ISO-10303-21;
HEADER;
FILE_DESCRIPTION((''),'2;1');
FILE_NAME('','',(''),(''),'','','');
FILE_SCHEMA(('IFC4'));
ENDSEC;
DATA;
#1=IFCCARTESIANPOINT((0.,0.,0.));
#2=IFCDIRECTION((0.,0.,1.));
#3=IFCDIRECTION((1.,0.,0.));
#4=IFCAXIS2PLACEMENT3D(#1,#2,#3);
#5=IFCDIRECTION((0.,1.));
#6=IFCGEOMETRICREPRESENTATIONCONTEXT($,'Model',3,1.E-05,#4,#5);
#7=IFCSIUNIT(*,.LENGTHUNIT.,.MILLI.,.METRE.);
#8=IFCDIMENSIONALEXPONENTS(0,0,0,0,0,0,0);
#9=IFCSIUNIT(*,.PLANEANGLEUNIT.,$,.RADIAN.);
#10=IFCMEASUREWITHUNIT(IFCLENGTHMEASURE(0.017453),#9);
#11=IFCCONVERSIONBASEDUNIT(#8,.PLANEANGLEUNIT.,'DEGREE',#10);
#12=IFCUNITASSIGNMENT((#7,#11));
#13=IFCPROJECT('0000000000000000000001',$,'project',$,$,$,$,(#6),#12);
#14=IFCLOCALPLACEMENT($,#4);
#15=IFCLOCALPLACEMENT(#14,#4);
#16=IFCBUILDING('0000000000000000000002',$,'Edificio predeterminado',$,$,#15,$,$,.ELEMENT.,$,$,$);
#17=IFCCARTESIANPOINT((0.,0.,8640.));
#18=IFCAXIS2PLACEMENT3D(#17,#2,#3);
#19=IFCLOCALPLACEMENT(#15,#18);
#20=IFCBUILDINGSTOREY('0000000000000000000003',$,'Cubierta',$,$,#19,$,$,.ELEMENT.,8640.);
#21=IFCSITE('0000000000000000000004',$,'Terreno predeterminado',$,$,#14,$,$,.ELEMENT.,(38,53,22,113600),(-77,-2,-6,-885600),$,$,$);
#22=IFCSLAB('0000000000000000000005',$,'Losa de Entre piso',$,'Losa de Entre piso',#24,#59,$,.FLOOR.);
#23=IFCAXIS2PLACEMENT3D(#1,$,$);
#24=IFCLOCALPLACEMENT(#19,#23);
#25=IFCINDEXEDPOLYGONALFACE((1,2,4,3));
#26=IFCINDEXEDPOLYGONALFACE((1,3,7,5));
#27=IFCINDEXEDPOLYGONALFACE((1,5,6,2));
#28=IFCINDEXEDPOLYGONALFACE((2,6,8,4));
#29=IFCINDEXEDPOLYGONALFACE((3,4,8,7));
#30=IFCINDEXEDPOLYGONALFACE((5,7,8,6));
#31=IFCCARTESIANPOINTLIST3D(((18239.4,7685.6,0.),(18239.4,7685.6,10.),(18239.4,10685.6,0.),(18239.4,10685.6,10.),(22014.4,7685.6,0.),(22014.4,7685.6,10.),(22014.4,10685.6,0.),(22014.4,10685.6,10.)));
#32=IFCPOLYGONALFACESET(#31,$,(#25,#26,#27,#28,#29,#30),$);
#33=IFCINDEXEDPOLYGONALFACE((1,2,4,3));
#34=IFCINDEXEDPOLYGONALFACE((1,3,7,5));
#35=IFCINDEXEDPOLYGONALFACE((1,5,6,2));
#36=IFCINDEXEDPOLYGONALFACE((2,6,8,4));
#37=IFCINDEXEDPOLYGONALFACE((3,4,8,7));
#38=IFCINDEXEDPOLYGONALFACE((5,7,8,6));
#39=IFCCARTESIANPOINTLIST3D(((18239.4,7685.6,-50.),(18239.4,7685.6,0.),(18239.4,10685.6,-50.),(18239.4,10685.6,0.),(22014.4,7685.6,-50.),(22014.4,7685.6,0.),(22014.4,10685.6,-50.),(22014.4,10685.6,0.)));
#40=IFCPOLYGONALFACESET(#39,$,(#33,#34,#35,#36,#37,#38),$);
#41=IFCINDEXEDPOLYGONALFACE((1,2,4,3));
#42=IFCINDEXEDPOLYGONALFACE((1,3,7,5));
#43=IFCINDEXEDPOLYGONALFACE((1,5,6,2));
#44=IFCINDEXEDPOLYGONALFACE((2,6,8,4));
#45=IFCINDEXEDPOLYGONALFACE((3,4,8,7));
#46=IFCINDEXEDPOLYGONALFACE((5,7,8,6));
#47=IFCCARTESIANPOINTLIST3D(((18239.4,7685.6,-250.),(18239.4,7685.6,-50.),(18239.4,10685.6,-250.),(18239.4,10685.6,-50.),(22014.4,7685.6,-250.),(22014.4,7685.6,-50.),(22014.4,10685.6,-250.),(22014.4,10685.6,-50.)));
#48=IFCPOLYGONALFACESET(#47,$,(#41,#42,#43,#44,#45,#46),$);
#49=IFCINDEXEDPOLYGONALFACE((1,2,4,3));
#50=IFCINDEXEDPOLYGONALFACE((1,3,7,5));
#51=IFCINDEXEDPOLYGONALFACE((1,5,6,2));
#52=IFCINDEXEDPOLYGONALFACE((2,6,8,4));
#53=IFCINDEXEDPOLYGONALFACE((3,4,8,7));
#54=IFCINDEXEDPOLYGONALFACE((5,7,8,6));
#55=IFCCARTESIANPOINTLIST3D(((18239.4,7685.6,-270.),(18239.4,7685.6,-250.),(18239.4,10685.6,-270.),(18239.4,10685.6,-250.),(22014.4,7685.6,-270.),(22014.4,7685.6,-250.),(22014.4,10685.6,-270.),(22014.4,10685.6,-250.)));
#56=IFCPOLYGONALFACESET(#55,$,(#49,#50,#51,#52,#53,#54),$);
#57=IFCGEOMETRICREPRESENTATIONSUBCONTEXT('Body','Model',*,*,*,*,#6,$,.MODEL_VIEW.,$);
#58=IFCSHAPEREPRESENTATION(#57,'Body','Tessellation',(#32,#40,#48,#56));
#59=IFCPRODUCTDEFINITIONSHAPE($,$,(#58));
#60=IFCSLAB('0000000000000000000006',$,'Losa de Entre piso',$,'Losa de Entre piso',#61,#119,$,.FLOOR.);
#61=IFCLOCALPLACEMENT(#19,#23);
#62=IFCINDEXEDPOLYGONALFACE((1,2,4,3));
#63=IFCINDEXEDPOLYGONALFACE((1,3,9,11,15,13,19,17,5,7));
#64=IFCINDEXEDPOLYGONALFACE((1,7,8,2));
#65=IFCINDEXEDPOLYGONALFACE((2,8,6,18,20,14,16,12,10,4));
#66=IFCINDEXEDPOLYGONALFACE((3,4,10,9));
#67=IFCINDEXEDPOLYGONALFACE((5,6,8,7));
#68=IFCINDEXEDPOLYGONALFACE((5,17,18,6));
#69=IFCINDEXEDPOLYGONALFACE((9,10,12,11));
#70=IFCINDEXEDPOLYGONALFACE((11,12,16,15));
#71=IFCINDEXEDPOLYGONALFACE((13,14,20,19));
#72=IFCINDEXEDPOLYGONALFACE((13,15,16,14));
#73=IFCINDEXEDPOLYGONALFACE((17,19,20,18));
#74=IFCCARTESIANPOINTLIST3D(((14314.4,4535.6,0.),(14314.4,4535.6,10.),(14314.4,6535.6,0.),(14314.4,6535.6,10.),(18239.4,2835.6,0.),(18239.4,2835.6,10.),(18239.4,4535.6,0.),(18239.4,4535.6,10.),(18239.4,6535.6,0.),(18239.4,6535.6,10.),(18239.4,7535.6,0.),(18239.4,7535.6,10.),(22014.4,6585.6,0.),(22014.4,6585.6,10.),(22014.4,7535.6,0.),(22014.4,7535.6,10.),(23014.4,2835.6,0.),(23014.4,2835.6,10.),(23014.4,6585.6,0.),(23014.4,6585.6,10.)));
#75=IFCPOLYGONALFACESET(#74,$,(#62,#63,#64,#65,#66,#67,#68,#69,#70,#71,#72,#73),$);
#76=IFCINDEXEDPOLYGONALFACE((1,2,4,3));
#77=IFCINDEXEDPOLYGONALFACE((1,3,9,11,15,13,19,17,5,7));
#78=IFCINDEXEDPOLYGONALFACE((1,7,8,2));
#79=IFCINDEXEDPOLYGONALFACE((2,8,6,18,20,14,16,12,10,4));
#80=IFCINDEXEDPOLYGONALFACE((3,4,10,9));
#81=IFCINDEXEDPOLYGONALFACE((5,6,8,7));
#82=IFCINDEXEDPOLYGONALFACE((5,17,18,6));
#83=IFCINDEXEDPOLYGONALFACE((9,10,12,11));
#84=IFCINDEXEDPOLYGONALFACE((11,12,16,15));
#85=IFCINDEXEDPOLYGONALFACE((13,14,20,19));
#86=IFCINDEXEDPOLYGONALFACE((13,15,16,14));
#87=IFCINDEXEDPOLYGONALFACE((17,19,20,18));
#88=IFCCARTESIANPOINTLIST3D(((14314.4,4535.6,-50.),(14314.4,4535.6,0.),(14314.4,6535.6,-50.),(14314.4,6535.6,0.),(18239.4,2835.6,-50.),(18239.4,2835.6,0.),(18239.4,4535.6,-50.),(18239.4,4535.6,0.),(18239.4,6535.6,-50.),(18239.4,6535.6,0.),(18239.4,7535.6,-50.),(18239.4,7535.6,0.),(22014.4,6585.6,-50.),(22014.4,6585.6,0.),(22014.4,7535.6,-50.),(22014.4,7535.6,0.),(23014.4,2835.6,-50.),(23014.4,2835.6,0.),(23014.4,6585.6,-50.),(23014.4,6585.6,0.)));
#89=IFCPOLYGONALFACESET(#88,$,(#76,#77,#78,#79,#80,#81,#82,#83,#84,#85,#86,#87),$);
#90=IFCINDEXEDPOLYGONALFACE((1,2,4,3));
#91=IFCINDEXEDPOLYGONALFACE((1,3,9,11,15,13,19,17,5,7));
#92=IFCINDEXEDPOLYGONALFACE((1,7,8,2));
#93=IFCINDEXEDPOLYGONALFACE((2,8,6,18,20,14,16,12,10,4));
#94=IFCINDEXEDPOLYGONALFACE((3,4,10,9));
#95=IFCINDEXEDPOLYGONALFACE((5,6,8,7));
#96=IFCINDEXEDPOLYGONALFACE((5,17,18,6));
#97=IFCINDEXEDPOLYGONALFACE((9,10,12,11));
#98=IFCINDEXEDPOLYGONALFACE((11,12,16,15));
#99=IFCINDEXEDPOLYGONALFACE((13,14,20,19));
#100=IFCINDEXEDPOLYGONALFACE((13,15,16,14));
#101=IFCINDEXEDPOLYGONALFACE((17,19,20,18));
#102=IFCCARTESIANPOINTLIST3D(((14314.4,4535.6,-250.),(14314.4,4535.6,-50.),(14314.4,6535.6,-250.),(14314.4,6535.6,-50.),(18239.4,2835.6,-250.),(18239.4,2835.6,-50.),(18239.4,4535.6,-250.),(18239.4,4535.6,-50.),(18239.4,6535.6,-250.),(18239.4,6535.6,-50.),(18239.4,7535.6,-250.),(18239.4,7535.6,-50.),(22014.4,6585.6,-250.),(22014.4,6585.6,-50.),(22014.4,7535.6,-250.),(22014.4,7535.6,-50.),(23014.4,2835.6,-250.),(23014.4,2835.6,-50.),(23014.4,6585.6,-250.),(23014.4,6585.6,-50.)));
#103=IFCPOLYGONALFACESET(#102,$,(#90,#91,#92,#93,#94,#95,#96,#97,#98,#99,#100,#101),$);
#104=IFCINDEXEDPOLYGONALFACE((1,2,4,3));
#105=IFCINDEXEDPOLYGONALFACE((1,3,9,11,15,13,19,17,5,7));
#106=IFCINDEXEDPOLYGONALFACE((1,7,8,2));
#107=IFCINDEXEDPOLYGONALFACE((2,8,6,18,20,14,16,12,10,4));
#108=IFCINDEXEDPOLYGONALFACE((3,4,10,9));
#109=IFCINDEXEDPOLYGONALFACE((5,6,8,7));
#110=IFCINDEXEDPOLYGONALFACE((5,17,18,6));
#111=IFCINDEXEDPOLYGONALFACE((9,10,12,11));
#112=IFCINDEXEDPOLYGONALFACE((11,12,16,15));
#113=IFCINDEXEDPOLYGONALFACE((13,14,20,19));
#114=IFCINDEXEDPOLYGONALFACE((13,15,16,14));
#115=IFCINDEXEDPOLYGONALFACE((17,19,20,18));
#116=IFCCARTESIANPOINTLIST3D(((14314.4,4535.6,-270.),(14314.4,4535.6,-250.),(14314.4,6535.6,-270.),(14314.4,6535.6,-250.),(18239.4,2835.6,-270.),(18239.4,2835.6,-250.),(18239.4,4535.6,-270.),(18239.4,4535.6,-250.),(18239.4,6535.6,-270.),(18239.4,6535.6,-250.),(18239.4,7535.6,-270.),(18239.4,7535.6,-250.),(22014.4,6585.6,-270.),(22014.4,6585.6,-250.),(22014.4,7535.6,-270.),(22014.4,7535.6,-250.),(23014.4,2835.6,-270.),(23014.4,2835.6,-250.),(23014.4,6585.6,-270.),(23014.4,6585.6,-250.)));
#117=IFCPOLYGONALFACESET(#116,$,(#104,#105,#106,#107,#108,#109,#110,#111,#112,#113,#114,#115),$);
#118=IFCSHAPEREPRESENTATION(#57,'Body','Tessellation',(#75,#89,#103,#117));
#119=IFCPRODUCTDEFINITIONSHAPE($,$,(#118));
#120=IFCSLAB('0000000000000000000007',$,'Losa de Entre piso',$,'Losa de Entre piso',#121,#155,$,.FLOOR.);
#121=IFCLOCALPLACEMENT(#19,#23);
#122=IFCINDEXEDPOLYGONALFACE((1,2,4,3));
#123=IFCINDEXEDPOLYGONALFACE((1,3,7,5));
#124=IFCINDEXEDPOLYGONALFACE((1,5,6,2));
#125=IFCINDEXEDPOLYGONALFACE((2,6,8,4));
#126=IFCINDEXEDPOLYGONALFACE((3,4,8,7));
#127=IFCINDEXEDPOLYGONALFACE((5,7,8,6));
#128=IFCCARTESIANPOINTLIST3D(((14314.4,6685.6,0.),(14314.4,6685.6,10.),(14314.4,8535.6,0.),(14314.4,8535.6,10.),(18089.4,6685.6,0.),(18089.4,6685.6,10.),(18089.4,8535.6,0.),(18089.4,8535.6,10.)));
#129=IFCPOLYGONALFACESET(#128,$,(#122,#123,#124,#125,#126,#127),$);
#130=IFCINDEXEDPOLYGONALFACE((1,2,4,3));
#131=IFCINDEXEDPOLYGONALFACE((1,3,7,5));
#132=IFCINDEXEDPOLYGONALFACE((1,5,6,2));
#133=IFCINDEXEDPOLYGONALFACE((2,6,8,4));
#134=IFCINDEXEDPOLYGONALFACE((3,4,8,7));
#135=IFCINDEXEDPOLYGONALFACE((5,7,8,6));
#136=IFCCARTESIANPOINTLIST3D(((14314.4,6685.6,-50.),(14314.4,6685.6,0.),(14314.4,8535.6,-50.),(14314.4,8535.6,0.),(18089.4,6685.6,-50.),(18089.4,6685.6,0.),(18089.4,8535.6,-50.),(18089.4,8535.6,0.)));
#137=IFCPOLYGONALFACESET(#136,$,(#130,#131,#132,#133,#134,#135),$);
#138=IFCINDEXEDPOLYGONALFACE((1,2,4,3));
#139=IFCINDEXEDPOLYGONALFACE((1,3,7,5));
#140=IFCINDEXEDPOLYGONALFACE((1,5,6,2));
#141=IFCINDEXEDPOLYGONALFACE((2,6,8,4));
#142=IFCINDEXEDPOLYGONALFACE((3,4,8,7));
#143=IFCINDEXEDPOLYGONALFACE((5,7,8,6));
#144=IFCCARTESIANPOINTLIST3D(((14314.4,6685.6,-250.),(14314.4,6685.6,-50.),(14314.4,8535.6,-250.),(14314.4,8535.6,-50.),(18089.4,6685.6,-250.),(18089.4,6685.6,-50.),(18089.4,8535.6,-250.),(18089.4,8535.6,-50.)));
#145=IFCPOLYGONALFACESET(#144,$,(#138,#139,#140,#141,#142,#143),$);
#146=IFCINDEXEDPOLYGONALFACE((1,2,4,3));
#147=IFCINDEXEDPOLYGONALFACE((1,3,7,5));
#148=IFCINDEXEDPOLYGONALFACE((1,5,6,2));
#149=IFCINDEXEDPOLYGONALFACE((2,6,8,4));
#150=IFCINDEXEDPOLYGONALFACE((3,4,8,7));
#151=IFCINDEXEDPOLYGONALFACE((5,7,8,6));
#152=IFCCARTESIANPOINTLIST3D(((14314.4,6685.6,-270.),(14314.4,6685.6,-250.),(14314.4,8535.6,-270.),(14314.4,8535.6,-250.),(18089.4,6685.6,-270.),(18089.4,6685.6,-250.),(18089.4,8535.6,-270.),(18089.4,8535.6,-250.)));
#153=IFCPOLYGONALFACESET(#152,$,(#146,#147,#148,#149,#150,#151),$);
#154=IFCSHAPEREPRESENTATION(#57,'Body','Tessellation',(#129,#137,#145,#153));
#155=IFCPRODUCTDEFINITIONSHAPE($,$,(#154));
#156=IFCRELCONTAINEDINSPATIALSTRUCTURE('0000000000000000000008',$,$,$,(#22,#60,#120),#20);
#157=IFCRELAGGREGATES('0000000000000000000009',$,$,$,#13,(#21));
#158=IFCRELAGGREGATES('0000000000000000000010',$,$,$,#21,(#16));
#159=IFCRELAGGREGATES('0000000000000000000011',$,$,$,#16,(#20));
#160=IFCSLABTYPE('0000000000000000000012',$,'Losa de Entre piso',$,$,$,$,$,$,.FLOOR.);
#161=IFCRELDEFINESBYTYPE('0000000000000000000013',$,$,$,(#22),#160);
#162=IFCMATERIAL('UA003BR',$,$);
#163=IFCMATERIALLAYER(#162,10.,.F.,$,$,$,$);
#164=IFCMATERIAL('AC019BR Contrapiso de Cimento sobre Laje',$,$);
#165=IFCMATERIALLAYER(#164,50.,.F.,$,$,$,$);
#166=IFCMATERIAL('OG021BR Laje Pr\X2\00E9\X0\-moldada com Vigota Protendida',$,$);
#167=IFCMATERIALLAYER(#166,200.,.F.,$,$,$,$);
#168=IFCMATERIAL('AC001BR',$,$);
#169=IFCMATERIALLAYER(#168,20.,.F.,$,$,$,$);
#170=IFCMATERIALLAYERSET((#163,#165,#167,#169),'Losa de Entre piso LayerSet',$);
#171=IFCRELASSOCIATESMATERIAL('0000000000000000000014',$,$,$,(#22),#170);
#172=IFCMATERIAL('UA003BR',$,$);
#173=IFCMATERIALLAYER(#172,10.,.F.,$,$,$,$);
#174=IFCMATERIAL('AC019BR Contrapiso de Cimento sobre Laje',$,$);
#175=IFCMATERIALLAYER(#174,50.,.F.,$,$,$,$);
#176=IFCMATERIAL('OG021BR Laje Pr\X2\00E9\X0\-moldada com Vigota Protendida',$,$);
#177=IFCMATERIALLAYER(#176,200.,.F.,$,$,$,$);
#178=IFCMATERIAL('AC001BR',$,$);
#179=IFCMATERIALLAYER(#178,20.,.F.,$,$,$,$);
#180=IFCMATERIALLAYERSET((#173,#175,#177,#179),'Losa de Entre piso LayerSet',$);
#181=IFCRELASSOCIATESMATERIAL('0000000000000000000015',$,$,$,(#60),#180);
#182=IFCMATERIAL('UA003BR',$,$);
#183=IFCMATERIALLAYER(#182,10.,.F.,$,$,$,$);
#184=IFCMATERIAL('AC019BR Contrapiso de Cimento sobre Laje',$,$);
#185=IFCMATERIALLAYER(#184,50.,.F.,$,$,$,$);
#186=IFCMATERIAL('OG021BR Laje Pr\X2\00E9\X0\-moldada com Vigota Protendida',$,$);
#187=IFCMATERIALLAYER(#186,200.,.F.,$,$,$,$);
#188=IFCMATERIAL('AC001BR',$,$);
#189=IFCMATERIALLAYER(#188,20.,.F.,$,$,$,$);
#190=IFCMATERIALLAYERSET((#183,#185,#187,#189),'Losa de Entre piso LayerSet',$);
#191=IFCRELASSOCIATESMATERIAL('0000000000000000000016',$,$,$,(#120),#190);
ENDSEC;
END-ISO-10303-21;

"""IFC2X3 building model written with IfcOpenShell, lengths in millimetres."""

from ifc_helpers import new_model, entity, si_unit, converted_unit, direction, frame, origin_with_axes, place, context, subcontext, project, spatial, polyline, outline, extrude, material, layer, layer_set, layer_usage, type_object, element, save


model = new_model("IFC2X3")

# Units and contexts
model_context = context("Model", 3, precision=1e-05, world=origin_with_axes(), true_north=direction((0.0, 1.0)))
body_context = subcontext(model_context, "Body", "Model", "MODEL_VIEW")
ifc_project = project(units=[si_unit("LENGTHUNIT", "METRE", prefix="MILLI"), converted_unit("PLANEANGLEUNIT", "DEGREE", entity("IfcLengthMeasure", 0.017453), si_unit("PLANEANGLEUNIT", "RADIAN"), dimensions=[0, 0, 0, 0, 0, 0, 0])], contexts=[model_context])

# Site, building, storey
site_placement = place(None, origin_with_axes())
site = spatial("IfcSite", under=ifc_project, at=site_placement, Name="Terreno predeterminado", CompositionType="ELEMENT", RefLatitude=(38, 53, 22, 113600), RefLongitude=(-77, -2, -6, -885600))
building_placement = place(site_placement, origin_with_axes())
building = spatial("IfcBuilding", under=site, at=building_placement, Name="Edificio predeterminado", CompositionType="ELEMENT")
storey_placement = place(building_placement, frame((0.0, 0.0, 8640.0), z_axis=(0.0, 0.0, 1.0), x_axis=(1.0, 0.0, 0.0)))
storey = spatial("IfcBuildingStorey", under=building, at=storey_placement, Name="Cubierta", CompositionType="ELEMENT", Elevation=8640.0)

# Slabs
ifc_material_1 = material(Name="UA003BR")
ifc_layer_1 = layer(ifc_material_1, 10.0, ventilated=False)
ifc_material_2 = material(Name="AC019BR Contrapiso de Cimento sobre Laje")
ifc_layer_2 = layer(ifc_material_2, 50.0, ventilated=False)
ifc_material_3 = material(Name="OG021BR Laje Pré-moldada com Vigota Protendida")
ifc_layer_3 = layer(ifc_material_3, 200.0, ventilated=False)
ifc_material_4 = material(Name="AC001BR")
ifc_layer_4 = layer(ifc_material_4, 20.0, ventilated=False)
ifc_layer_set_1 = layer_set([ifc_layer_1, ifc_layer_2, ifc_layer_3, ifc_layer_4], Name="Losa de Entre piso LayerSet")
ifc_layer_usage_1 = layer_usage(ifc_layer_set_1, "AXIS3", "NEGATIVE", 0.0)
slab_type = type_object("IfcSlabType", Name="Losa de Entre piso", PredefinedType="FLOOR")
slab_1_placement = place(storey_placement, frame((0.0, 0.0, -8640.0), z_axis=(0.0, 0.0, 1.0), x_axis=(1.0, 0.0, 0.0)))
element("IfcSlab", 1, at=slab_1_placement, inside=storey, type_object=slab_type, material=ifc_layer_usage_1, Name="Losa de Entre piso", ObjectType="Losa de Entre piso", PredefinedType="FLOOR", context=body_context, shape_type="SweptSolid", body=[
    extrude(outline(polyline([(0.0, 3000.0), (3775.0, 3000.0), (3775.0, 0.0), (0.0, 0.0), (0.0, 3000.0)])), frame((22014.4, 7685.6, 8640.0), z_axis=(0.0, 0.0, -1.0), x_axis=(-1.0, 0.0, 0.0)), (0.0, 0.0, -1.0), 10.0),
    extrude(outline(polyline([(0.0, 3000.0), (3775.0, 3000.0), (3775.0, 0.0), (0.0, 0.0), (0.0, 3000.0)])), frame((22014.4, 7685.6, 8590.0), z_axis=(0.0, 0.0, -1.0), x_axis=(-1.0, 0.0, 0.0)), (0.0, 0.0, -1.0), 50.0),
    extrude(outline(polyline([(0.0, 3000.0), (3775.0, 3000.0), (3775.0, 0.0), (0.0, 0.0), (0.0, 3000.0)])), frame((22014.4, 7685.6, 8390.0), z_axis=(0.0, 0.0, -1.0), x_axis=(-1.0, 0.0, 0.0)), (0.0, 0.0, -1.0), 200.0),
    extrude(outline(polyline([(0.0, 3000.0), (3775.0, 3000.0), (3775.0, 0.0), (0.0, 0.0), (0.0, 3000.0)])), frame((22014.4, 7685.6, 8370.0), z_axis=(0.0, 0.0, -1.0), x_axis=(-1.0, 0.0, 0.0)), (0.0, 0.0, -1.0), 20.0),
])
ifc_material_5 = material(Name="UA003BR")
ifc_layer_5 = layer(ifc_material_5, 10.0, ventilated=False)
ifc_material_6 = material(Name="AC019BR Contrapiso de Cimento sobre Laje")
ifc_layer_6 = layer(ifc_material_6, 50.0, ventilated=False)
ifc_material_7 = material(Name="OG021BR Laje Pré-moldada com Vigota Protendida")
ifc_layer_7 = layer(ifc_material_7, 200.0, ventilated=False)
ifc_material_8 = material(Name="AC001BR")
ifc_layer_8 = layer(ifc_material_8, 20.0, ventilated=False)
ifc_layer_set_2 = layer_set([ifc_layer_5, ifc_layer_6, ifc_layer_7, ifc_layer_8], Name="Losa de Entre piso LayerSet")
ifc_layer_usage_2 = layer_usage(ifc_layer_set_2, "AXIS3", "NEGATIVE", 0.0)
slab_2_placement = place(storey_placement, frame((0.0, 0.0, -8640.0), z_axis=(0.0, 0.0, 1.0), x_axis=(1.0, 0.0, 0.0)))
element("IfcSlab", 2, at=slab_2_placement, inside=storey, material=ifc_layer_usage_2, Name="Losa de Entre piso", ObjectType="Losa de Entre piso", PredefinedType="FLOOR", context=body_context, shape_type="SweptSolid", body=[
    extrude(outline(polyline([(0.0, 1000.0), (-3925.0, 1000.0), (-3925.0, 3000.0), (0.0, 3000.0), (0.0, 4700.0), (4775.0, 4700.0), (4775.0, 950.0), (3775.0, 950.0), (3775.0, 0.0), (0.0, 0.0), (0.0, 1000.0)])), frame((18239.4, 7535.6, 8640.0), z_axis=(0.0, 0.0, -1.0), x_axis=(1.0, 0.0, 0.0)), (0.0, 0.0, -1.0), 10.0),
    extrude(outline(polyline([(0.0, 1000.0), (-3925.0, 1000.0), (-3925.0, 3000.0), (0.0, 3000.0), (0.0, 4700.0), (4775.0, 4700.0), (4775.0, 950.0), (3775.0, 950.0), (3775.0, 0.0), (0.0, 0.0), (0.0, 1000.0)])), frame((18239.4, 7535.6, 8590.0), z_axis=(0.0, 0.0, -1.0), x_axis=(1.0, 0.0, 0.0)), (0.0, 0.0, -1.0), 50.0),
    extrude(outline(polyline([(0.0, 1000.0), (-3925.0, 1000.0), (-3925.0, 3000.0), (0.0, 3000.0), (0.0, 4700.0), (4775.0, 4700.0), (4775.0, 950.0), (3775.0, 950.0), (3775.0, 0.0), (0.0, 0.0), (0.0, 1000.0)])), frame((18239.4, 7535.6, 8390.0), z_axis=(0.0, 0.0, -1.0), x_axis=(1.0, 0.0, 0.0)), (0.0, 0.0, -1.0), 200.0),
    extrude(outline(polyline([(0.0, 1000.0), (-3925.0, 1000.0), (-3925.0, 3000.0), (0.0, 3000.0), (0.0, 4700.0), (4775.0, 4700.0), (4775.0, 950.0), (3775.0, 950.0), (3775.0, 0.0), (0.0, 0.0), (0.0, 1000.0)])), frame((18239.4, 7535.6, 8370.0), z_axis=(0.0, 0.0, -1.0), x_axis=(1.0, 0.0, 0.0)), (0.0, 0.0, -1.0), 20.0),
])
ifc_material_9 = material(Name="UA003BR")
ifc_layer_9 = layer(ifc_material_9, 10.0, ventilated=False)
ifc_material_10 = material(Name="AC019BR Contrapiso de Cimento sobre Laje")
ifc_layer_10 = layer(ifc_material_10, 50.0, ventilated=False)
ifc_material_11 = material(Name="OG021BR Laje Pré-moldada com Vigota Protendida")
ifc_layer_11 = layer(ifc_material_11, 200.0, ventilated=False)
ifc_material_12 = material(Name="AC001BR")
ifc_layer_12 = layer(ifc_material_12, 20.0, ventilated=False)
ifc_layer_set_3 = layer_set([ifc_layer_9, ifc_layer_10, ifc_layer_11, ifc_layer_12], Name="Losa de Entre piso LayerSet")
ifc_layer_usage_3 = layer_usage(ifc_layer_set_3, "AXIS3", "NEGATIVE", 0.0)
slab_3_placement = place(storey_placement, frame((0.0, 0.0, -8640.0), z_axis=(0.0, 0.0, 1.0), x_axis=(1.0, 0.0, 0.0)))
element("IfcSlab", 3, at=slab_3_placement, inside=storey, material=ifc_layer_usage_3, Name="Losa de Entre piso", ObjectType="Losa de Entre piso", PredefinedType="FLOOR", context=body_context, shape_type="SweptSolid", body=[
    extrude(outline(polyline([(0.0, 1850.0), (3775.0, 1850.0), (3775.0, 0.0), (0.0, 0.0), (0.0, 1850.0)])), frame((18089.4, 6685.6, 8640.0), z_axis=(0.0, 0.0, -1.0), x_axis=(-1.0, 0.0, 0.0)), (0.0, 0.0, -1.0), 10.0),
    extrude(outline(polyline([(0.0, 1850.0), (3775.0, 1850.0), (3775.0, 0.0), (0.0, 0.0), (0.0, 1850.0)])), frame((18089.4, 6685.6, 8590.0), z_axis=(0.0, 0.0, -1.0), x_axis=(-1.0, 0.0, 0.0)), (0.0, 0.0, -1.0), 50.0),
    extrude(outline(polyline([(0.0, 1850.0), (3775.0, 1850.0), (3775.0, 0.0), (0.0, 0.0), (0.0, 1850.0)])), frame((18089.4, 6685.6, 8390.0), z_axis=(0.0, 0.0, -1.0), x_axis=(-1.0, 0.0, 0.0)), (0.0, 0.0, -1.0), 200.0),
    extrude(outline(polyline([(0.0, 1850.0), (3775.0, 1850.0), (3775.0, 0.0), (0.0, 0.0), (0.0, 1850.0)])), frame((18089.4, 6685.6, 8370.0), z_axis=(0.0, 0.0, -1.0), x_axis=(-1.0, 0.0, 0.0)), (0.0, 0.0, -1.0), 20.0),
])

save(model, "model.ifc")
